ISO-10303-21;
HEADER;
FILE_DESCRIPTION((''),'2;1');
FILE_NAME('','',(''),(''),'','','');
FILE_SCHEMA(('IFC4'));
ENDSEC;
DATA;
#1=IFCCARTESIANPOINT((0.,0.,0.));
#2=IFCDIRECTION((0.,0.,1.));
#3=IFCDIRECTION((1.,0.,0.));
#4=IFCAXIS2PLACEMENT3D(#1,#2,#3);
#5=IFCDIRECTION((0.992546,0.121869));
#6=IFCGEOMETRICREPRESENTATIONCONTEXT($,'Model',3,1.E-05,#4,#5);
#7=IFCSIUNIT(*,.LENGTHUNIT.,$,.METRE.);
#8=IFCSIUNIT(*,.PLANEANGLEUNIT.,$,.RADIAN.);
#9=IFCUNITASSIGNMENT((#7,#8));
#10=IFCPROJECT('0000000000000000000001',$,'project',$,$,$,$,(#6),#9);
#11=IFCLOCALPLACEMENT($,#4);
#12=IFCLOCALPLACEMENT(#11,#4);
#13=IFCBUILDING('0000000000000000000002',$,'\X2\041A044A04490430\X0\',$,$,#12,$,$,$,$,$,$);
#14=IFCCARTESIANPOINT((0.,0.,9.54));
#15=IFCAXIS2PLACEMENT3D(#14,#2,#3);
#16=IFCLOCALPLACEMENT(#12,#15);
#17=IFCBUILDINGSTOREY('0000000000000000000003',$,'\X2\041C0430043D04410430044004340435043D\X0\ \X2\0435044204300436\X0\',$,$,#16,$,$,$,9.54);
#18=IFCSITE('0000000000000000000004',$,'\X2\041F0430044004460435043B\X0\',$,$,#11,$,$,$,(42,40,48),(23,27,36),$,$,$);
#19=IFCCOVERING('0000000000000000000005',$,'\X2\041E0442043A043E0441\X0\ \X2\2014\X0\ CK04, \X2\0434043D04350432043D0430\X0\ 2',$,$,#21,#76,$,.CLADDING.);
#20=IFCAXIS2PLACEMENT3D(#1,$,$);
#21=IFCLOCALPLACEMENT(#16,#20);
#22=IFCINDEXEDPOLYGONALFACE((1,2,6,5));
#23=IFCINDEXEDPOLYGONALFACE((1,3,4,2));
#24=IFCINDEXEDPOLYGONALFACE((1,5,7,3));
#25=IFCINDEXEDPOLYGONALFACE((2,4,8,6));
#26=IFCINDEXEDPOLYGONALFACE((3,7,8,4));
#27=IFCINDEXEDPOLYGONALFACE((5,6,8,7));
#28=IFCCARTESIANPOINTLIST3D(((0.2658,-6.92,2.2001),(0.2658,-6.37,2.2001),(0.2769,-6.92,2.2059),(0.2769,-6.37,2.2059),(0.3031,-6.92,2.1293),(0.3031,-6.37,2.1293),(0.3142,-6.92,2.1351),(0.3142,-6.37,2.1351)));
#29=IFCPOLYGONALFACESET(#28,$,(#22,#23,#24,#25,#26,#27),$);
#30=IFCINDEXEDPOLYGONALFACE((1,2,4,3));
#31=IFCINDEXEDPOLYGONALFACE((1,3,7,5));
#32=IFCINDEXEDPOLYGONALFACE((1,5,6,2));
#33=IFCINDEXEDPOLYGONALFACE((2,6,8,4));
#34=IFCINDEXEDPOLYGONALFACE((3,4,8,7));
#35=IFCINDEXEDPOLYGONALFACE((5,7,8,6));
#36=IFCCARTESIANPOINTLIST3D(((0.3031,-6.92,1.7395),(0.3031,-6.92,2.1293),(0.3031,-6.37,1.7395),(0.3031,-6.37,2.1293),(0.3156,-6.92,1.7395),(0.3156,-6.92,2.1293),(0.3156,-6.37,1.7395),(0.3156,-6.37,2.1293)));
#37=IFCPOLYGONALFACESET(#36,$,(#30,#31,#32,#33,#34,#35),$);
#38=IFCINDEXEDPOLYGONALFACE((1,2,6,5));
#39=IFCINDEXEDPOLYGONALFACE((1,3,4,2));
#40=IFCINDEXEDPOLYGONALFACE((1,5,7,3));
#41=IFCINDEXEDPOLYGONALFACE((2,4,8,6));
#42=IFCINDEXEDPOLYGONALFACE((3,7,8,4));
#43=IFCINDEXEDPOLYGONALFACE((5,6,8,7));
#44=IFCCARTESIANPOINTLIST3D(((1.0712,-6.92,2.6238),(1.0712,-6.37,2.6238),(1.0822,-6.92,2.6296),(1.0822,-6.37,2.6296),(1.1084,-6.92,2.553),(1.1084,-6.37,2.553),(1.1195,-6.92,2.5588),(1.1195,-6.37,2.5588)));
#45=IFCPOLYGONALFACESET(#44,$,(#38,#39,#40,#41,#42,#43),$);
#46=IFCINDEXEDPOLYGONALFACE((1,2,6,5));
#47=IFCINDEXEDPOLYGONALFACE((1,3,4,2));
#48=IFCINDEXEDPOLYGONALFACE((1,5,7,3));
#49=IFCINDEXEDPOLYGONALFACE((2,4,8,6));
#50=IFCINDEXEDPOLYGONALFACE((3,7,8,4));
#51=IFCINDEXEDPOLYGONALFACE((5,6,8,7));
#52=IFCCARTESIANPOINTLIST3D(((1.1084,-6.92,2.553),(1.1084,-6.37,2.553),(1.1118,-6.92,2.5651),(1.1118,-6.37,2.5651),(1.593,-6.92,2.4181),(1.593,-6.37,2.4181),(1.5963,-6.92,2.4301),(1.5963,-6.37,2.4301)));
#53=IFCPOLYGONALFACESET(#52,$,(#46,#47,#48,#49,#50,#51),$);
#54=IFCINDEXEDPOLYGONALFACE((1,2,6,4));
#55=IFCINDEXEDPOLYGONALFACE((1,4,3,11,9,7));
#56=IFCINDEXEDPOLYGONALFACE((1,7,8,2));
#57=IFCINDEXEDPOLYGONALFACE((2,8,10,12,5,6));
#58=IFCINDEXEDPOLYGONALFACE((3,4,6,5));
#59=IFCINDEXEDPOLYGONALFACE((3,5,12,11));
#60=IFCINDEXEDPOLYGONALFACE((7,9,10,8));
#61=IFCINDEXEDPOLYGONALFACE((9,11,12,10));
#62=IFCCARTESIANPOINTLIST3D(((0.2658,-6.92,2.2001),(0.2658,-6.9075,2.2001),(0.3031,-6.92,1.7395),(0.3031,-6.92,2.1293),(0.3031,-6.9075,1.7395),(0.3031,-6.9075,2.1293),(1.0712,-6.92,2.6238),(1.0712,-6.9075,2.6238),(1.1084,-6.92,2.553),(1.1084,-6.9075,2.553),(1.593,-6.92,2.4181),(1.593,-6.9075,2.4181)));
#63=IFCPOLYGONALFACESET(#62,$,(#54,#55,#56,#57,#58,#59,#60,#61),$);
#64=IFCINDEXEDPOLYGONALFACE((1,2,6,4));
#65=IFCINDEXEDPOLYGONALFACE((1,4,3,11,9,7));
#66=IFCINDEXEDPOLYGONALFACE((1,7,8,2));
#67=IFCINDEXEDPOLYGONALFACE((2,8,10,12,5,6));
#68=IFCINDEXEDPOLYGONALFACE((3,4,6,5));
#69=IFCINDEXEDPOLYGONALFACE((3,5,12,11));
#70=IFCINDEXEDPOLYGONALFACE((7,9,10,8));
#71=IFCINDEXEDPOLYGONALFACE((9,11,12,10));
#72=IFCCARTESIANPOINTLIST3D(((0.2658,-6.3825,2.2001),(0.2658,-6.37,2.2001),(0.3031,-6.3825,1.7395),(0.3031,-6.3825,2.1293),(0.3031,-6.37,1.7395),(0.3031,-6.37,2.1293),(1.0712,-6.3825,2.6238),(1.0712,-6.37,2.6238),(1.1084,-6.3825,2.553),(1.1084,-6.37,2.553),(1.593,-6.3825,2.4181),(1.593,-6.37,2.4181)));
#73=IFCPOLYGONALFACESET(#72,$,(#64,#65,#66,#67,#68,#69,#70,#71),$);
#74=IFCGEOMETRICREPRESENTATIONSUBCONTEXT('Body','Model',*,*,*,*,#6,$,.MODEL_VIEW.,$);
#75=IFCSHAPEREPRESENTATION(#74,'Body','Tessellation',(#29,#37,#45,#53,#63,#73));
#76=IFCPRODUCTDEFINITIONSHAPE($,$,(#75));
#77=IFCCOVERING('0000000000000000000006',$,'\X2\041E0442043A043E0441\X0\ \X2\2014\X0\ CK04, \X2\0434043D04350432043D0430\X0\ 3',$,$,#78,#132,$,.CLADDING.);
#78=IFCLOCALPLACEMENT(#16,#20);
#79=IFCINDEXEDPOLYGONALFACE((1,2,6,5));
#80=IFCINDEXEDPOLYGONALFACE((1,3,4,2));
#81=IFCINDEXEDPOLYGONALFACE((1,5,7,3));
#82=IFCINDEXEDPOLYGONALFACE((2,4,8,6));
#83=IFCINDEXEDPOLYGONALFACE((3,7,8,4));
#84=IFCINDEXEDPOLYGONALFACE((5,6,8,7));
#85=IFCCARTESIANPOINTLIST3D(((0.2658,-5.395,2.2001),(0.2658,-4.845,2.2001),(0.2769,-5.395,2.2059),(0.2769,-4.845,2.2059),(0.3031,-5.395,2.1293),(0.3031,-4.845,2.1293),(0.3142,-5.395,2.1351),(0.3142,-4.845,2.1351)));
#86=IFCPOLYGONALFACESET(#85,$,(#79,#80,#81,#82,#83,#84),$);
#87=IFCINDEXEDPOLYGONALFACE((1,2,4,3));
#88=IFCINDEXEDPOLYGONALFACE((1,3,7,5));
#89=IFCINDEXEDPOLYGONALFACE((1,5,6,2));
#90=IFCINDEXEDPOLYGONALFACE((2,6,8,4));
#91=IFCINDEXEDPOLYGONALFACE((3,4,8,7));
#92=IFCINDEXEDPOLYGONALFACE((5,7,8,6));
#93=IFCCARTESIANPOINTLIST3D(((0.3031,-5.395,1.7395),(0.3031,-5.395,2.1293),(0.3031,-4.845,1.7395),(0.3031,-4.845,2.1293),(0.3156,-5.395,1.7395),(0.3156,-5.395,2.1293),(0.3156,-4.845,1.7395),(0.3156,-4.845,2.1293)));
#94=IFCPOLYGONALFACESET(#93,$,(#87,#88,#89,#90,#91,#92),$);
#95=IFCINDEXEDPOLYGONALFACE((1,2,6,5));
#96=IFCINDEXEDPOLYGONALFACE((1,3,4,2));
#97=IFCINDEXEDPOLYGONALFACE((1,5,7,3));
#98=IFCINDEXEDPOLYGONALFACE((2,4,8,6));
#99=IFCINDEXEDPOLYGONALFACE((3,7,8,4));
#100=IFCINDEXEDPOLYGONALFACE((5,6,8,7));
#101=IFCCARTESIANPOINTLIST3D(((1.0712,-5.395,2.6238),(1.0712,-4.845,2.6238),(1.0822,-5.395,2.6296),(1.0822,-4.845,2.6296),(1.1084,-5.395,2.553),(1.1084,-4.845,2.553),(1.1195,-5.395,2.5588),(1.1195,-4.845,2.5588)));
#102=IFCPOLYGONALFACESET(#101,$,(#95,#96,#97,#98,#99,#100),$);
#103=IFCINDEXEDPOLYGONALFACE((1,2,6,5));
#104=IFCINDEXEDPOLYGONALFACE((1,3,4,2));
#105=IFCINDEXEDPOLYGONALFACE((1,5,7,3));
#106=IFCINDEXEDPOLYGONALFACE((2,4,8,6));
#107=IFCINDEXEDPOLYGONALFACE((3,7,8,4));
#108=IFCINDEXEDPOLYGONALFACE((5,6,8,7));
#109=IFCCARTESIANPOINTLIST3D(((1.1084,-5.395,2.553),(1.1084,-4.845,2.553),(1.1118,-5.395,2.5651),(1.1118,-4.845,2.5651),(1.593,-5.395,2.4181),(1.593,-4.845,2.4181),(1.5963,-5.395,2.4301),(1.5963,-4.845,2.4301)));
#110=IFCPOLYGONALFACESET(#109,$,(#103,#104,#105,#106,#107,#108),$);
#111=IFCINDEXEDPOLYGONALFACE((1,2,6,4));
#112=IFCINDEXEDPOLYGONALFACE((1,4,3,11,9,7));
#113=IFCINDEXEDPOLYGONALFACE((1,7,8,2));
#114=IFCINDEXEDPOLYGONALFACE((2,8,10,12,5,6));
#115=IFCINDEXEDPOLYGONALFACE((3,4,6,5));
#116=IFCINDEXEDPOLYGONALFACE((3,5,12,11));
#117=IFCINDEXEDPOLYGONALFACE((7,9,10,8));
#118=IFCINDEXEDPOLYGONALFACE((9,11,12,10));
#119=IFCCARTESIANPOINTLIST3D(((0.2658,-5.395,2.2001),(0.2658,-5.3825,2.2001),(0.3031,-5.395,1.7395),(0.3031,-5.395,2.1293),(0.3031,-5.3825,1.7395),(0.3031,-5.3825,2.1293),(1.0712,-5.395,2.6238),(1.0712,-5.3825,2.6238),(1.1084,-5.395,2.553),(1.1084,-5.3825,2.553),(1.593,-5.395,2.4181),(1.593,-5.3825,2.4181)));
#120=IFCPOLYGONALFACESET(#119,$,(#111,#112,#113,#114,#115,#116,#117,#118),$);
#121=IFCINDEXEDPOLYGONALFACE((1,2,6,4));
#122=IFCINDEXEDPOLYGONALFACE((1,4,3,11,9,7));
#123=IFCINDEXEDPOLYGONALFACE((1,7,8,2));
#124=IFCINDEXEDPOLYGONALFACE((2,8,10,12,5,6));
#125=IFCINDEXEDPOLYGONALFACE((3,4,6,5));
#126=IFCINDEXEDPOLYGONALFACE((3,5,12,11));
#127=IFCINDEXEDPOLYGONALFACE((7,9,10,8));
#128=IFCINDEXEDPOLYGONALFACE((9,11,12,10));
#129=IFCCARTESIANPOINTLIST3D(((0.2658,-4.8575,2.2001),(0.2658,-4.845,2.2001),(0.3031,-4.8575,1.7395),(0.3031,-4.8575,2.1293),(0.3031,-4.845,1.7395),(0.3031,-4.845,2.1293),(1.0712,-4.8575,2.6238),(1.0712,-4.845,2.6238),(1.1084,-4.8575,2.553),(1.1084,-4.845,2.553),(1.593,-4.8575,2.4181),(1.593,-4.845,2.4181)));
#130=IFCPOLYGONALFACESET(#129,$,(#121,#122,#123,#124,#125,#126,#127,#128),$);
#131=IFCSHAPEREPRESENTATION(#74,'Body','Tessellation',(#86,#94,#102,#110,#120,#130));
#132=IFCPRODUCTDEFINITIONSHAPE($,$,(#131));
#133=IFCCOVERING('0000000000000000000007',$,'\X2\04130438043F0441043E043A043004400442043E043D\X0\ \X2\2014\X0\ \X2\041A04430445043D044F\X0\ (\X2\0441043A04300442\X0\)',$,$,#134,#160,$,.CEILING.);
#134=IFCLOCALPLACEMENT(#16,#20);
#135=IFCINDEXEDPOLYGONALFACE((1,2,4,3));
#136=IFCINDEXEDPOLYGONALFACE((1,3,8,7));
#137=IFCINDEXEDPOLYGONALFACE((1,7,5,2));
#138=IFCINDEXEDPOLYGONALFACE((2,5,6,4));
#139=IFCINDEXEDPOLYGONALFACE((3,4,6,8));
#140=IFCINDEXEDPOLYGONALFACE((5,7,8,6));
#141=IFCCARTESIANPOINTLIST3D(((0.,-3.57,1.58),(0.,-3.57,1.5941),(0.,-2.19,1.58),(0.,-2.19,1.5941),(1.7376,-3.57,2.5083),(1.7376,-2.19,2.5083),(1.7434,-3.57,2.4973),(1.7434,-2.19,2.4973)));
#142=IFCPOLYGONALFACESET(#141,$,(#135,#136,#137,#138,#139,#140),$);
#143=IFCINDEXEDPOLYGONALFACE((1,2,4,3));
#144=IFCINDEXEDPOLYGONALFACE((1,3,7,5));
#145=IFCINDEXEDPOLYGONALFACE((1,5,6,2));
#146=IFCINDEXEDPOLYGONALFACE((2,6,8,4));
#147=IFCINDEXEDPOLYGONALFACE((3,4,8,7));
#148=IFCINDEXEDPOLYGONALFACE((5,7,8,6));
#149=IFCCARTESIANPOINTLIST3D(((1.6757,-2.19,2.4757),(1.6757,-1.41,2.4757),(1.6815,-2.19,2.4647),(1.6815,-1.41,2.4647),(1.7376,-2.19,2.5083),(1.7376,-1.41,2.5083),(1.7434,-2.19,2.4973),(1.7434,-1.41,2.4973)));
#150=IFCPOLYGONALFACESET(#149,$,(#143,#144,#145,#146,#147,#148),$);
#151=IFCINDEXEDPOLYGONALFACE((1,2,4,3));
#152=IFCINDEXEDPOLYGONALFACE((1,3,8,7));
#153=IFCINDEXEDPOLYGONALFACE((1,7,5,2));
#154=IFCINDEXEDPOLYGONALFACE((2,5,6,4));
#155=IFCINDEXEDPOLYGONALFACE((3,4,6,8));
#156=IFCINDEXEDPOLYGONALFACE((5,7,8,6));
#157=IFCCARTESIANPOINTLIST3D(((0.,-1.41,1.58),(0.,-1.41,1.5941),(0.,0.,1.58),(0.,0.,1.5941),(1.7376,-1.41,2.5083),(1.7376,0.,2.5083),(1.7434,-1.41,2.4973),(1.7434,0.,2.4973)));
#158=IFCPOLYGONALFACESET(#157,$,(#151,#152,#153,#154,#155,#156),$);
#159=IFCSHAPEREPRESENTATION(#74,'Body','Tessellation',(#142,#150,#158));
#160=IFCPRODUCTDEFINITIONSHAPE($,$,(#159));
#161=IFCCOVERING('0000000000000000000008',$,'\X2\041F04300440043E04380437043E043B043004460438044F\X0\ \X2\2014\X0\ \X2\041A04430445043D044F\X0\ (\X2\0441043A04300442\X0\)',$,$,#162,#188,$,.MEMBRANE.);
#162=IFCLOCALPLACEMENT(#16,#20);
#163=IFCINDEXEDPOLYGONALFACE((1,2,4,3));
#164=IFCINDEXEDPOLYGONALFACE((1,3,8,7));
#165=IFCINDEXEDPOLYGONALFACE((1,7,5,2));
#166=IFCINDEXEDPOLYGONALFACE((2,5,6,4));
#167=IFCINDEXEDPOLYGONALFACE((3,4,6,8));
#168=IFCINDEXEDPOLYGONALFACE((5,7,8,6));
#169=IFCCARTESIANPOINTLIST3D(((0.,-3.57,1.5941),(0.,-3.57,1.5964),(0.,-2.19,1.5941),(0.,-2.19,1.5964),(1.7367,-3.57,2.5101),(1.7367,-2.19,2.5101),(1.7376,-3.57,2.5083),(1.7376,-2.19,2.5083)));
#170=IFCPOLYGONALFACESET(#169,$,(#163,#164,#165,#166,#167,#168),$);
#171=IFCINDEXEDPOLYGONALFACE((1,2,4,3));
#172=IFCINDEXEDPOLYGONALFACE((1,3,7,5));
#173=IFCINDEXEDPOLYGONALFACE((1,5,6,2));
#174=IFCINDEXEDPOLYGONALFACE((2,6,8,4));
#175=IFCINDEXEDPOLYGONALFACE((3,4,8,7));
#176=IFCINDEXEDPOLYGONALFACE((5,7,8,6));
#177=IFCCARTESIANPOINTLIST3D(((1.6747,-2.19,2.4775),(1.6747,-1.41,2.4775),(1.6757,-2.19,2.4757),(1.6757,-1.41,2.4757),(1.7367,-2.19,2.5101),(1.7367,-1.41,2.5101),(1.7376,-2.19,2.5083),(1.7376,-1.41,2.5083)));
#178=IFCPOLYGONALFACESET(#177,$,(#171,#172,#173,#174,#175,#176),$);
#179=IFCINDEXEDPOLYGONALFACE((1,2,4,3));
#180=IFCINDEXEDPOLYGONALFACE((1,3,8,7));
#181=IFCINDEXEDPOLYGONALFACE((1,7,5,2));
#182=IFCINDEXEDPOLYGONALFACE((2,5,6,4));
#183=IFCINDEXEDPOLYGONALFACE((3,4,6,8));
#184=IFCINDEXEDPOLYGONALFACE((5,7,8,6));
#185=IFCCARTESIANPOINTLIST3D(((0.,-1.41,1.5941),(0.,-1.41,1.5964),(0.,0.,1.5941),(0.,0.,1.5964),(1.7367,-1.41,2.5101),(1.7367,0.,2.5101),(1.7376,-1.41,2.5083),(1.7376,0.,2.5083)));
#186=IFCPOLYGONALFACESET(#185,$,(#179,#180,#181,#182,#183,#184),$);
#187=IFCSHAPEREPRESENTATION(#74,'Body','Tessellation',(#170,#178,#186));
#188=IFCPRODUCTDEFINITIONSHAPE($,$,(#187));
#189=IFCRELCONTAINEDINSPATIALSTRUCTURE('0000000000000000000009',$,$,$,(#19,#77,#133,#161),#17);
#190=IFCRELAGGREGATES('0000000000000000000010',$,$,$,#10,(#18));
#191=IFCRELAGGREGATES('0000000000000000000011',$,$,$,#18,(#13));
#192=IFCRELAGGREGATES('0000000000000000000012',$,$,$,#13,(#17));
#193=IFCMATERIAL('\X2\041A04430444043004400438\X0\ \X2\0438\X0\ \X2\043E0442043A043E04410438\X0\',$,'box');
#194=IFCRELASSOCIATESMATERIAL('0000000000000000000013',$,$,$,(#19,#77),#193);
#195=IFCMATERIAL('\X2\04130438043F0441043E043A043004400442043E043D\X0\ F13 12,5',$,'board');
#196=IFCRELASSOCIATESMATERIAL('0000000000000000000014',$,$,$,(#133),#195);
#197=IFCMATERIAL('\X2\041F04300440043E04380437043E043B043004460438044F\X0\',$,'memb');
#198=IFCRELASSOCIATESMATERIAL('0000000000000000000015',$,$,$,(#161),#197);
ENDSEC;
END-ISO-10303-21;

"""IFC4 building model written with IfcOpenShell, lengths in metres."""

from ifc_helpers import new_model, si_unit, direction, frame, origin_with_axes, place, context, subcontext, project, spatial, polyline, outline, extrude, material, element, save


model = new_model("IFC4")

# Units and contexts
model_context = context("Model", 3, precision=1e-05, world=origin_with_axes(), true_north=direction((0.992546, 0.121869)))
body_context = subcontext(model_context, "Body", "Model", "MODEL_VIEW")
ifc_project = project(units=[si_unit("LENGTHUNIT", "METRE"), si_unit("PLANEANGLEUNIT", "RADIAN")], contexts=[model_context])

# Site, building, storey
site_placement = place(None, origin_with_axes())
site = spatial("IfcSite", under=ifc_project, at=site_placement, Name="Парцел", RefLatitude=(42, 40, 48), RefLongitude=(23, 27, 36))
building_placement = place(site_placement, origin_with_axes())
building = spatial("IfcBuilding", under=site, at=building_placement, Name="Къща")
storey_placement = place(building_placement, frame((0.0, 0.0, 9.54), z_axis=(0.0, 0.0, 1.0), x_axis=(1.0, 0.0, 0.0)))
storey = spatial("IfcBuildingStorey", under=building, at=storey_placement, Name="Мансарден етаж", Elevation=9.54)

# Coverings
ifc_material_1 = material(Name="Куфари и откоси", Category="box")
covering_1_placement = place(storey_placement, origin_with_axes())
element("IfcCovering", 1, at=covering_1_placement, inside=storey, material=ifc_material_1, Name="Откос — CK04, дневна 2", PredefinedType="CLADDING", context=body_context, shape_type="SweptSolid", body=[
    extrude(outline(polyline([(0.2658, -2.2001), (0.3031, -2.1293), (0.3142, -2.1351), (0.2769, -2.2059), (0.2658, -2.2001)])), frame((0.0, -6.92, 0.0), z_axis=(0.0, 1.0, 0.0), x_axis=(1.0, 0.0, 0.0)), (0.0, 0.0, 1.0), 0.55),
    extrude(outline(polyline([(0.3031, -2.1293), (0.3031, -1.7395), (0.3156, -1.7395), (0.3156, -2.1293), (0.3031, -2.1293)])), frame((0.0, -6.92, 0.0), z_axis=(0.0, 1.0, 0.0), x_axis=(1.0, 0.0, 0.0)), (0.0, 0.0, 1.0), 0.55),
    extrude(outline(polyline([(1.0712, -2.6238), (1.1084, -2.553), (1.1195, -2.5588), (1.0822, -2.6296), (1.0712, -2.6238)])), frame((0.0, -6.92, 0.0), z_axis=(0.0, 1.0, 0.0), x_axis=(1.0, 0.0, 0.0)), (0.0, 0.0, 1.0), 0.55),
    extrude(outline(polyline([(1.1084, -2.553), (1.593, -2.4181), (1.5963, -2.4301), (1.1118, -2.5651), (1.1084, -2.553)])), frame((0.0, -6.92, 0.0), z_axis=(0.0, 1.0, 0.0), x_axis=(1.0, 0.0, 0.0)), (0.0, 0.0, 1.0), 0.55),
    extrude(outline(polyline([(0.3031, -1.7395), (0.3031, -2.1293), (0.2658, -2.2001), (1.0712, -2.6238), (1.1084, -2.553), (1.593, -2.4181), (0.3031, -1.7395)])), frame((0.0, -6.92, 0.0), z_axis=(0.0, 1.0, 0.0), x_axis=(1.0, 0.0, 0.0)), (0.0, 0.0, 1.0), 0.0125),
    extrude(outline(polyline([(0.3031, -1.7395), (0.3031, -2.1293), (0.2658, -2.2001), (1.0712, -2.6238), (1.1084, -2.553), (1.593, -2.4181), (0.3031, -1.7395)])), frame((0.0, -6.3825, 0.0), z_axis=(0.0, 1.0, 0.0), x_axis=(1.0, 0.0, 0.0)), (0.0, 0.0, 1.0), 0.0125),
])
covering_2_placement = place(storey_placement, origin_with_axes())
element("IfcCovering", 2, at=covering_2_placement, inside=storey, material=ifc_material_1, Name="Откос — CK04, дневна 3", PredefinedType="CLADDING", context=body_context, shape_type="SweptSolid", body=[
    extrude(outline(polyline([(0.2658, -2.2001), (0.3031, -2.1293), (0.3142, -2.1351), (0.2769, -2.2059), (0.2658, -2.2001)])), frame((0.0, -5.395, 0.0), z_axis=(0.0, 1.0, 0.0), x_axis=(1.0, 0.0, 0.0)), (0.0, 0.0, 1.0), 0.55),
    extrude(outline(polyline([(0.3031, -2.1293), (0.3031, -1.7395), (0.3156, -1.7395), (0.3156, -2.1293), (0.3031, -2.1293)])), frame((0.0, -5.395, 0.0), z_axis=(0.0, 1.0, 0.0), x_axis=(1.0, 0.0, 0.0)), (0.0, 0.0, 1.0), 0.55),
    extrude(outline(polyline([(1.0712, -2.6238), (1.1084, -2.553), (1.1195, -2.5588), (1.0822, -2.6296), (1.0712, -2.6238)])), frame((0.0, -5.395, 0.0), z_axis=(0.0, 1.0, 0.0), x_axis=(1.0, 0.0, 0.0)), (0.0, 0.0, 1.0), 0.55),
    extrude(outline(polyline([(1.1084, -2.553), (1.593, -2.4181), (1.5963, -2.4301), (1.1118, -2.5651), (1.1084, -2.553)])), frame((0.0, -5.395, 0.0), z_axis=(0.0, 1.0, 0.0), x_axis=(1.0, 0.0, 0.0)), (0.0, 0.0, 1.0), 0.55),
    extrude(outline(polyline([(0.3031, -1.7395), (0.3031, -2.1293), (0.2658, -2.2001), (1.0712, -2.6238), (1.1084, -2.553), (1.593, -2.4181), (0.3031, -1.7395)])), frame((0.0, -5.395, 0.0), z_axis=(0.0, 1.0, 0.0), x_axis=(1.0, 0.0, 0.0)), (0.0, 0.0, 1.0), 0.0125),
    extrude(outline(polyline([(0.3031, -1.7395), (0.3031, -2.1293), (0.2658, -2.2001), (1.0712, -2.6238), (1.1084, -2.553), (1.593, -2.4181), (0.3031, -1.7395)])), frame((0.0, -4.8575, 0.0), z_axis=(0.0, 1.0, 0.0), x_axis=(1.0, 0.0, 0.0)), (0.0, 0.0, 1.0), 0.0125),
])
ifc_material_2 = material(Name="Гипсокартон F13 12,5", Category="board")
covering_3_placement = place(storey_placement, origin_with_axes())
element("IfcCovering", 3, at=covering_3_placement, inside=storey, material=ifc_material_2, Name="Гипсокартон — Кухня (скат)", PredefinedType="CEILING", context=body_context, shape_type="SweptSolid", body=[
    extrude(outline(polyline([(0.0, -1.58), (1.7434, -2.4973), (1.7376, -2.5083), (0.0, -1.5941), (0.0, -1.58)])), frame((0.0, -3.57, 0.0), z_axis=(0.0, 1.0, 0.0), x_axis=(1.0, 0.0, 0.0)), (0.0, 0.0, 1.0), 1.38),
    extrude(outline(polyline([(1.6815, -2.4647), (1.7434, -2.4973), (1.7376, -2.5083), (1.6757, -2.4757), (1.6815, -2.4647)])), frame((0.0, -2.19, 0.0), z_axis=(0.0, 1.0, 0.0), x_axis=(1.0, 0.0, 0.0)), (0.0, 0.0, 1.0), 0.78),
    extrude(outline(polyline([(0.0, -1.58), (1.7434, -2.4973), (1.7376, -2.5083), (0.0, -1.5941), (0.0, -1.58)])), frame((0.0, -1.41, 0.0), z_axis=(0.0, 1.0, 0.0), x_axis=(1.0, 0.0, 0.0)), (0.0, 0.0, 1.0), 1.41),
])
ifc_material_3 = material(Name="Пароизолация", Category="memb")
covering_4_placement = place(storey_placement, origin_with_axes())
element("IfcCovering", 4, at=covering_4_placement, inside=storey, material=ifc_material_3, Name="Пароизолация — Кухня (скат)", PredefinedType="MEMBRANE", context=body_context, shape_type="SweptSolid", body=[
    extrude(outline(polyline([(0.0, -1.5941), (1.7376, -2.5083), (1.7367, -2.5101), (0.0, -1.5964), (0.0, -1.5941)])), frame((0.0, -3.57, 0.0), z_axis=(0.0, 1.0, 0.0), x_axis=(1.0, 0.0, 0.0)), (0.0, 0.0, 1.0), 1.38),
    extrude(outline(polyline([(1.6757, -2.4757), (1.7376, -2.5083), (1.7367, -2.5101), (1.6747, -2.4775), (1.6757, -2.4757)])), frame((0.0, -2.19, 0.0), z_axis=(0.0, 1.0, 0.0), x_axis=(1.0, 0.0, 0.0)), (0.0, 0.0, 1.0), 0.78),
    extrude(outline(polyline([(0.0, -1.5941), (1.7376, -2.5083), (1.7367, -2.5101), (0.0, -1.5964), (0.0, -1.5941)])), frame((0.0, -1.41, 0.0), z_axis=(0.0, 1.0, 0.0), x_axis=(1.0, 0.0, 0.0)), (0.0, 0.0, 1.0), 1.41),
])

save(model, "model.ifc")
